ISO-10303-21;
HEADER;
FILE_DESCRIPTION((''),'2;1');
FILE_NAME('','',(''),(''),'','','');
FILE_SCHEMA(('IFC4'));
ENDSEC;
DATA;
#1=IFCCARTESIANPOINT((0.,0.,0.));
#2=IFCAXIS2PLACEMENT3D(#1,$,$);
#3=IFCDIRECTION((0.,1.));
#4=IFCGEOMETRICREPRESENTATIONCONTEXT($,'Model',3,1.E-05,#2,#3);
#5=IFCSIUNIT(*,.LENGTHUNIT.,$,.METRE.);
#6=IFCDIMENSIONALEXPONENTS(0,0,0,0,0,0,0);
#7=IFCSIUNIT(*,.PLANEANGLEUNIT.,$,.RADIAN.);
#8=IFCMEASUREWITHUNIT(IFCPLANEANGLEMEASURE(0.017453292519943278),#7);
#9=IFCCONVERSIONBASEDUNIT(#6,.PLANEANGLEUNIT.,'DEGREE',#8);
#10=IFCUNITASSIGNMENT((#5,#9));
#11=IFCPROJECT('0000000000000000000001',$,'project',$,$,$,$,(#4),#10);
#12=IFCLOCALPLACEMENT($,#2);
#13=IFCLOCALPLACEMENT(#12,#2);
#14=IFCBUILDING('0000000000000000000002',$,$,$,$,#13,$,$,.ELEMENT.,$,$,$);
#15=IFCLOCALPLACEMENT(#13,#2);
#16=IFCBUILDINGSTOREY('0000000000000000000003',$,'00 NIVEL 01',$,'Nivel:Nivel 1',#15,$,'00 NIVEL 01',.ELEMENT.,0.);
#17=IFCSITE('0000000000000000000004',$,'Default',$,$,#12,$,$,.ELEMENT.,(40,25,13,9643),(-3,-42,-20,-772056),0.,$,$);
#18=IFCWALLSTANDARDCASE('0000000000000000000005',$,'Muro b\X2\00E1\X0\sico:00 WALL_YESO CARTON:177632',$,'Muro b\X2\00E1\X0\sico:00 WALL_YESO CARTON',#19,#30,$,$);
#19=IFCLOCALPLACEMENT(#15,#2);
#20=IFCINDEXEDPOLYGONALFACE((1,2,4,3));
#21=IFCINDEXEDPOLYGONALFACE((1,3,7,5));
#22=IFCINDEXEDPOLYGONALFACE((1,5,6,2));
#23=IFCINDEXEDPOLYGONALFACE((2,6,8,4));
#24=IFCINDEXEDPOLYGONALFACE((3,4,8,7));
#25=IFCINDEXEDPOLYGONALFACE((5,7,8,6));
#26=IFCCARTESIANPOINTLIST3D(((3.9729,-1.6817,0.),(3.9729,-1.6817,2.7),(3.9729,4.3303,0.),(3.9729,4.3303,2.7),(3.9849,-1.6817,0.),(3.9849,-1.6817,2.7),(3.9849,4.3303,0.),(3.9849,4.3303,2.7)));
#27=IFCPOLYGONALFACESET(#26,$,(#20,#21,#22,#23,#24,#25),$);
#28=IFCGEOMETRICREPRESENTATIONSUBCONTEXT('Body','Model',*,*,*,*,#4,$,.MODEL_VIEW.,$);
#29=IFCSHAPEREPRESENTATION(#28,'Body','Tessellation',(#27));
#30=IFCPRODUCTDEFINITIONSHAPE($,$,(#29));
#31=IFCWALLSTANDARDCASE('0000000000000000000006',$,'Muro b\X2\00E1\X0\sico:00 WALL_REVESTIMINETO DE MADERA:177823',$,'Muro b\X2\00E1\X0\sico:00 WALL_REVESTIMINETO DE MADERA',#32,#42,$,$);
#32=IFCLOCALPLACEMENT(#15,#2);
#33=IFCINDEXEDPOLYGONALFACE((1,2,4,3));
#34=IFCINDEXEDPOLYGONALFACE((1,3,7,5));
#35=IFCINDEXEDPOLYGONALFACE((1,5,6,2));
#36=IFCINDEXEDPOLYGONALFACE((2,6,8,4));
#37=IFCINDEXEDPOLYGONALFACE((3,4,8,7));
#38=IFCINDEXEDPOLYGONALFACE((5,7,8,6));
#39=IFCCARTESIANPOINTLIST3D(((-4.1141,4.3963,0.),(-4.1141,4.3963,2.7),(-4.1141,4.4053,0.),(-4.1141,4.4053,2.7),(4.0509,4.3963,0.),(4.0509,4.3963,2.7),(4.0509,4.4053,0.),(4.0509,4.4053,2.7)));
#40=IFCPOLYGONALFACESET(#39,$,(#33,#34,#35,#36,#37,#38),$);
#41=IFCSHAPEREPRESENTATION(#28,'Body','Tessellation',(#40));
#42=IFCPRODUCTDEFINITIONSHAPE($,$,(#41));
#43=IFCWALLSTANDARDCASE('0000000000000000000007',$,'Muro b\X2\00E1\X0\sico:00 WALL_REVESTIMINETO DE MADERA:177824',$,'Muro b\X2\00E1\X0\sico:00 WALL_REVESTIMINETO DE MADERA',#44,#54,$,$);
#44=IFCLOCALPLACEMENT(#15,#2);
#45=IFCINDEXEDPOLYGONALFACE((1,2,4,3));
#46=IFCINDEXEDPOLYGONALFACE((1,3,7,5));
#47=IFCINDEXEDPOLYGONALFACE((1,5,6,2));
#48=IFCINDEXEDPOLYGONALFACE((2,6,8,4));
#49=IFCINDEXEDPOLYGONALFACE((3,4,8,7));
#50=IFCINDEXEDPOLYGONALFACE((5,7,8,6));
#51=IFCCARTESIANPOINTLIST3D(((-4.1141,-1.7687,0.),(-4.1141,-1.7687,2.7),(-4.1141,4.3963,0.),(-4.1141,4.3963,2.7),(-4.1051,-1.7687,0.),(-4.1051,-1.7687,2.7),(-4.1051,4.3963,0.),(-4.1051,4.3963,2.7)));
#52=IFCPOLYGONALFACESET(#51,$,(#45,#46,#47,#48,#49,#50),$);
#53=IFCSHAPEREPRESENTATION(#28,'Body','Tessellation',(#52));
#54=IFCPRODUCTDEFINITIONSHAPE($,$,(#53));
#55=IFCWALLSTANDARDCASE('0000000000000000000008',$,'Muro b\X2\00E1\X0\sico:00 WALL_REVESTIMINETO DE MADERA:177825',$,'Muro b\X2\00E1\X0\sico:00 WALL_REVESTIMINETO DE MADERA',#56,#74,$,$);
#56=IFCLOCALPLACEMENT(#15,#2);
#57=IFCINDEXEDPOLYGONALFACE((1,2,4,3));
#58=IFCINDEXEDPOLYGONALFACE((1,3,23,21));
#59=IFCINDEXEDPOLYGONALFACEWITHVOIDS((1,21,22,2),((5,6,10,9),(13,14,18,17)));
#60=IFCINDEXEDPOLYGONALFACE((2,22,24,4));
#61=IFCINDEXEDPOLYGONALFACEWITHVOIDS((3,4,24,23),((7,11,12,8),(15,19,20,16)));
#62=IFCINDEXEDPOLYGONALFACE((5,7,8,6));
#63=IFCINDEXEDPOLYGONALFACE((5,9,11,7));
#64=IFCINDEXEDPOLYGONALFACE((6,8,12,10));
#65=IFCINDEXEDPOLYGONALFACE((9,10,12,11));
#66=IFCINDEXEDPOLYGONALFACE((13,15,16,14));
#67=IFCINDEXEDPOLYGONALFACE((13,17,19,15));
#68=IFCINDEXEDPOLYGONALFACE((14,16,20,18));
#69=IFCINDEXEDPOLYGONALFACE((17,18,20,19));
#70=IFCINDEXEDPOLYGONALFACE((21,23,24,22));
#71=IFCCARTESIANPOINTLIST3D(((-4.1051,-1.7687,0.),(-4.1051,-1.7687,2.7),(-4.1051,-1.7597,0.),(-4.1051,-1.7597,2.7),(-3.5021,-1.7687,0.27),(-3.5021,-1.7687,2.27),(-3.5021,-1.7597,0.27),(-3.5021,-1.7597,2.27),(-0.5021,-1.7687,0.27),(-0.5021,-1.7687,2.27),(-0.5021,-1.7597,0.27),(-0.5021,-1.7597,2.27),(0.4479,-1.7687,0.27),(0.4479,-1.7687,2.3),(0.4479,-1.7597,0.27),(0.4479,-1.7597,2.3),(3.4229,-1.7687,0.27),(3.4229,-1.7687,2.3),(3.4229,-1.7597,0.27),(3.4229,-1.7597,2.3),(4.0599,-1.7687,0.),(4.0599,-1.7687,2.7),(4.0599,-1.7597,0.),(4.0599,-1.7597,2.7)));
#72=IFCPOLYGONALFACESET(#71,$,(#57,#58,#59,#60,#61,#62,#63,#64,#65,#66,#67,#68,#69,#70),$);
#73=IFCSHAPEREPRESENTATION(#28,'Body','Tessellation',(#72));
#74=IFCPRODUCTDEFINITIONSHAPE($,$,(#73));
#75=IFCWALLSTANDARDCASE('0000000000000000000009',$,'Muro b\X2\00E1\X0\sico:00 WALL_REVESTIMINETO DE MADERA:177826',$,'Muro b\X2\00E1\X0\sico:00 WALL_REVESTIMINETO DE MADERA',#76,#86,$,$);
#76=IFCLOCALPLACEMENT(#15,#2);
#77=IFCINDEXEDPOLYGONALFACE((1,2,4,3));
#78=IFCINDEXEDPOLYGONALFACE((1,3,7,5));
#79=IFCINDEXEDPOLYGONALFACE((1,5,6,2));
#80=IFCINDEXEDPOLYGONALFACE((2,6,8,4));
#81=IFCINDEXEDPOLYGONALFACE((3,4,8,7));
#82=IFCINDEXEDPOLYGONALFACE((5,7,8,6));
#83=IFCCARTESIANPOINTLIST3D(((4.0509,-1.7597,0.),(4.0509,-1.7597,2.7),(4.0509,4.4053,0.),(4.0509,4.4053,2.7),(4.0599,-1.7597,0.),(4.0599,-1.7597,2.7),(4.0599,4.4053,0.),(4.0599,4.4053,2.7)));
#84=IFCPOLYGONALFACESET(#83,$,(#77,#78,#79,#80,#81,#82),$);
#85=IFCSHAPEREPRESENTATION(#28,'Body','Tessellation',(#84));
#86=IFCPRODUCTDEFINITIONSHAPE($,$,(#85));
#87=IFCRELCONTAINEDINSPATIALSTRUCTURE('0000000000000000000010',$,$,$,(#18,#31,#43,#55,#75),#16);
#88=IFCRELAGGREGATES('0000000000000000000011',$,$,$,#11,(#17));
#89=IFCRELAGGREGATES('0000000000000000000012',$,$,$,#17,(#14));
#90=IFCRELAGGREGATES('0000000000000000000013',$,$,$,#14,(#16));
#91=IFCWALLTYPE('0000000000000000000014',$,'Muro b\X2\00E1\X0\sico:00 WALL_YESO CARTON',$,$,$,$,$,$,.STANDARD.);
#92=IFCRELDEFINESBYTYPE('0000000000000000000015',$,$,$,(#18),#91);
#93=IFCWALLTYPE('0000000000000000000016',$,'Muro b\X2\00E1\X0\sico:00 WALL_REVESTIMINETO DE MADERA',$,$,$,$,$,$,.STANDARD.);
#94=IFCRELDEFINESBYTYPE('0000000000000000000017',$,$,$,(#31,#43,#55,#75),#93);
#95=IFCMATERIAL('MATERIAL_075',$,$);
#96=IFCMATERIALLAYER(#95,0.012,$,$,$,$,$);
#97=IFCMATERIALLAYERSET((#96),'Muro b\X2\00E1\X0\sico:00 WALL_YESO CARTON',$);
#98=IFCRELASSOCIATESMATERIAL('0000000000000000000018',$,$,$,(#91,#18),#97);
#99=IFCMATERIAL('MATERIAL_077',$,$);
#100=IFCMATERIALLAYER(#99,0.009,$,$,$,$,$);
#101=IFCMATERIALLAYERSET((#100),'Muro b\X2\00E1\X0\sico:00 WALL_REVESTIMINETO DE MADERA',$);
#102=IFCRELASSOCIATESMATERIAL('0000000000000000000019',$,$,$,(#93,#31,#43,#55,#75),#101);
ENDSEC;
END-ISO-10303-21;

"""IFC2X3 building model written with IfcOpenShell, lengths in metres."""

from ifc_helpers import new_model, entity, si_unit, converted_unit, direction, frame, frame_2d, origin, place, context, subcontext, project, spatial, rectangle, extrude, material, layer, layer_set, layer_usage, type_object, element, save


model = new_model("IFC2X3")

# Units and contexts
model_context = context("Model", 3, precision=1e-05, world=origin(), true_north=direction((0.0, 1.0)))
body_context = subcontext(model_context, "Body", "Model", "MODEL_VIEW")
ifc_project = project(units=[si_unit("LENGTHUNIT", "METRE"), converted_unit("PLANEANGLEUNIT", "DEGREE", entity("IfcPlaneAngleMeasure", 0.017453292519943278), si_unit("PLANEANGLEUNIT", "RADIAN"), dimensions=[0, 0, 0, 0, 0, 0, 0])], contexts=[model_context])

# Site, building, storey
site_placement = place(None, origin())
site = spatial("IfcSite", under=ifc_project, at=site_placement, Name="Default", CompositionType="ELEMENT", RefLatitude=(40, 25, 13, 9643), RefLongitude=(-3, -42, -20, -772056), RefElevation=0.0)
building_placement = place(site_placement, origin())
building = spatial("IfcBuilding", under=site, at=building_placement, CompositionType="ELEMENT")
storey_placement = place(building_placement, origin())
storey = spatial("IfcBuildingStorey", under=building, at=storey_placement, Name="00 NIVEL 01", ObjectType="Nivel:Nivel 1", LongName="00 NIVEL 01", CompositionType="ELEMENT", Elevation=0.0)

# Shared definitions
ifc_material_1 = material(Name="MATERIAL_075")
ifc_layer_1 = layer(ifc_material_1, 0.012)
ifc_layer_set_1 = layer_set([ifc_layer_1], Name="Muro básico:00 WALL_YESO CARTON")
wall_type_1 = type_object("IfcWallType", Name="Muro básico:00 WALL_YESO CARTON", PredefinedType="STANDARD", material=ifc_layer_set_1)

# Walls
ifc_layer_usage_1 = layer_usage(ifc_layer_set_1, "AXIS2", "NEGATIVE", 0.006)
wall_1_placement = place(storey_placement, frame((3.9789, 4.3303, 0.0), z_axis=(0.0, 0.0, 1.0), x_axis=(0.0, -1.0, 0.0)))
element("IfcWallStandardCase", 1, at=wall_1_placement, inside=storey, type_object=wall_type_1, material=ifc_layer_usage_1, Name="Muro básico:00 WALL_YESO CARTON:177632", ObjectType="Muro básico:00 WALL_YESO CARTON", context=body_context, shape_type="SweptSolid", body=[
    extrude(rectangle(XDim=6.012, YDim=0.012, at=frame_2d((3.006, 0.0), x_axis=(-1.0, 0.0))), origin(), (0.0, 0.0, 1.0), 2.7),
])
ifc_material_2 = material(Name="MATERIAL_077")
ifc_layer_2 = layer(ifc_material_2, 0.009)
ifc_layer_set_2 = layer_set([ifc_layer_2], Name="Muro básico:00 WALL_REVESTIMINETO DE MADERA")
ifc_layer_usage_2 = layer_usage(ifc_layer_set_2, "AXIS2", "NEGATIVE", 0.0045)
wall_type_2 = type_object("IfcWallType", Name="Muro básico:00 WALL_REVESTIMINETO DE MADERA", PredefinedType="STANDARD", material=ifc_layer_set_2)
wall_2_placement = place(storey_placement, frame((-4.1141, 4.4008, 0.0)))
element("IfcWallStandardCase", 2, at=wall_2_placement, inside=storey, type_object=wall_type_2, material=ifc_layer_usage_2, Name="Muro básico:00 WALL_REVESTIMINETO DE MADERA:177823", ObjectType="Muro básico:00 WALL_REVESTIMINETO DE MADERA", context=body_context, shape_type="SweptSolid", body=[
    extrude(rectangle(XDim=8.165, YDim=0.009, at=frame_2d((4.0825, 0.0), x_axis=(-1.0, 0.0))), origin(), (0.0, 0.0, 1.0), 2.7),
])
ifc_layer_usage_3 = layer_usage(ifc_layer_set_2, "AXIS2", "NEGATIVE", 0.0045)
wall_3_placement = place(storey_placement, frame((-4.1096, -1.7687, 0.0), z_axis=(0.0, 0.0, 1.0), x_axis=(0.0, 1.0, 0.0)))
element("IfcWallStandardCase", 3, at=wall_3_placement, inside=storey, type_object=wall_type_2, material=ifc_layer_usage_3, Name="Muro básico:00 WALL_REVESTIMINETO DE MADERA:177824", ObjectType="Muro básico:00 WALL_REVESTIMINETO DE MADERA", context=body_context, shape_type="SweptSolid", body=[
    extrude(rectangle(XDim=6.165, YDim=0.009, at=frame_2d((3.0825, 0.0), x_axis=(-1.0, 0.0))), origin(), (0.0, 0.0, 1.0), 2.7),
])

# Wall, openings
ifc_layer_usage_4 = layer_usage(ifc_layer_set_2, "AXIS2", "NEGATIVE", 0.0045)
wall_4_placement = place(storey_placement, frame((4.0599, -1.7642, 0.0), z_axis=(0.0, 0.0, 1.0), x_axis=(-1.0, 0.0, 0.0)))
wall_4 = element("IfcWallStandardCase", 4, at=wall_4_placement, inside=storey, type_object=wall_type_2, material=ifc_layer_usage_4, Name="Muro básico:00 WALL_REVESTIMINETO DE MADERA:177825", ObjectType="Muro básico:00 WALL_REVESTIMINETO DE MADERA", context=body_context, shape_type="SweptSolid", body=[
    extrude(rectangle(XDim=8.165, YDim=0.009, at=frame_2d((4.0825, 0.0), x_axis=(-1.0, 0.0))), origin(), (0.0, 0.0, 1.0), 2.7),
])
opening_1_placement = place(wall_4_placement, origin())
element("IfcOpeningElement", 5, at=opening_1_placement, cuts=wall_4, ObjectType="Opening", context=body_context, shape_type="SweptSolid", body=[
    extrude(rectangle(XDim=2.0, YDim=3.0, at=frame_2d((0.0, 0.0), x_axis=(1.0, 0.0))), frame((6.062, 0.0045, 1.27), z_axis=(0.0, -1.0, 0.0), x_axis=(0.0, 0.0, -1.0)), (0.0, 0.0, 1.0), 0.009),
])
opening_2_placement = place(wall_4_placement, origin())
element("IfcOpeningElement", 6, at=opening_2_placement, cuts=wall_4, ObjectType="Opening", context=body_context, shape_type="SweptSolid", body=[
    extrude(rectangle(XDim=2.03, YDim=2.975, at=frame_2d((0.0, 0.0), x_axis=(1.0, 0.0))), frame((2.1245, 0.0045, 1.285), z_axis=(0.0, -1.0, 0.0), x_axis=(0.0, 0.0, -1.0)), (0.0, 0.0, 1.0), 0.009),
])

# Wall
ifc_layer_usage_5 = layer_usage(ifc_layer_set_2, "AXIS2", "NEGATIVE", 0.0045)
wall_5_placement = place(storey_placement, frame((4.0554, 4.4053, 0.0), z_axis=(0.0, 0.0, 1.0), x_axis=(0.0, -1.0, 0.0)))
element("IfcWallStandardCase", 7, at=wall_5_placement, inside=storey, type_object=wall_type_2, material=ifc_layer_usage_5, Name="Muro básico:00 WALL_REVESTIMINETO DE MADERA:177826", ObjectType="Muro básico:00 WALL_REVESTIMINETO DE MADERA", context=body_context, shape_type="SweptSolid", body=[
    extrude(rectangle(XDim=6.165, YDim=0.009, at=frame_2d((3.0825, 0.0), x_axis=(-1.0, 0.0))), origin(), (0.0, 0.0, 1.0), 2.7),
])

save(model, "model.ifc")
